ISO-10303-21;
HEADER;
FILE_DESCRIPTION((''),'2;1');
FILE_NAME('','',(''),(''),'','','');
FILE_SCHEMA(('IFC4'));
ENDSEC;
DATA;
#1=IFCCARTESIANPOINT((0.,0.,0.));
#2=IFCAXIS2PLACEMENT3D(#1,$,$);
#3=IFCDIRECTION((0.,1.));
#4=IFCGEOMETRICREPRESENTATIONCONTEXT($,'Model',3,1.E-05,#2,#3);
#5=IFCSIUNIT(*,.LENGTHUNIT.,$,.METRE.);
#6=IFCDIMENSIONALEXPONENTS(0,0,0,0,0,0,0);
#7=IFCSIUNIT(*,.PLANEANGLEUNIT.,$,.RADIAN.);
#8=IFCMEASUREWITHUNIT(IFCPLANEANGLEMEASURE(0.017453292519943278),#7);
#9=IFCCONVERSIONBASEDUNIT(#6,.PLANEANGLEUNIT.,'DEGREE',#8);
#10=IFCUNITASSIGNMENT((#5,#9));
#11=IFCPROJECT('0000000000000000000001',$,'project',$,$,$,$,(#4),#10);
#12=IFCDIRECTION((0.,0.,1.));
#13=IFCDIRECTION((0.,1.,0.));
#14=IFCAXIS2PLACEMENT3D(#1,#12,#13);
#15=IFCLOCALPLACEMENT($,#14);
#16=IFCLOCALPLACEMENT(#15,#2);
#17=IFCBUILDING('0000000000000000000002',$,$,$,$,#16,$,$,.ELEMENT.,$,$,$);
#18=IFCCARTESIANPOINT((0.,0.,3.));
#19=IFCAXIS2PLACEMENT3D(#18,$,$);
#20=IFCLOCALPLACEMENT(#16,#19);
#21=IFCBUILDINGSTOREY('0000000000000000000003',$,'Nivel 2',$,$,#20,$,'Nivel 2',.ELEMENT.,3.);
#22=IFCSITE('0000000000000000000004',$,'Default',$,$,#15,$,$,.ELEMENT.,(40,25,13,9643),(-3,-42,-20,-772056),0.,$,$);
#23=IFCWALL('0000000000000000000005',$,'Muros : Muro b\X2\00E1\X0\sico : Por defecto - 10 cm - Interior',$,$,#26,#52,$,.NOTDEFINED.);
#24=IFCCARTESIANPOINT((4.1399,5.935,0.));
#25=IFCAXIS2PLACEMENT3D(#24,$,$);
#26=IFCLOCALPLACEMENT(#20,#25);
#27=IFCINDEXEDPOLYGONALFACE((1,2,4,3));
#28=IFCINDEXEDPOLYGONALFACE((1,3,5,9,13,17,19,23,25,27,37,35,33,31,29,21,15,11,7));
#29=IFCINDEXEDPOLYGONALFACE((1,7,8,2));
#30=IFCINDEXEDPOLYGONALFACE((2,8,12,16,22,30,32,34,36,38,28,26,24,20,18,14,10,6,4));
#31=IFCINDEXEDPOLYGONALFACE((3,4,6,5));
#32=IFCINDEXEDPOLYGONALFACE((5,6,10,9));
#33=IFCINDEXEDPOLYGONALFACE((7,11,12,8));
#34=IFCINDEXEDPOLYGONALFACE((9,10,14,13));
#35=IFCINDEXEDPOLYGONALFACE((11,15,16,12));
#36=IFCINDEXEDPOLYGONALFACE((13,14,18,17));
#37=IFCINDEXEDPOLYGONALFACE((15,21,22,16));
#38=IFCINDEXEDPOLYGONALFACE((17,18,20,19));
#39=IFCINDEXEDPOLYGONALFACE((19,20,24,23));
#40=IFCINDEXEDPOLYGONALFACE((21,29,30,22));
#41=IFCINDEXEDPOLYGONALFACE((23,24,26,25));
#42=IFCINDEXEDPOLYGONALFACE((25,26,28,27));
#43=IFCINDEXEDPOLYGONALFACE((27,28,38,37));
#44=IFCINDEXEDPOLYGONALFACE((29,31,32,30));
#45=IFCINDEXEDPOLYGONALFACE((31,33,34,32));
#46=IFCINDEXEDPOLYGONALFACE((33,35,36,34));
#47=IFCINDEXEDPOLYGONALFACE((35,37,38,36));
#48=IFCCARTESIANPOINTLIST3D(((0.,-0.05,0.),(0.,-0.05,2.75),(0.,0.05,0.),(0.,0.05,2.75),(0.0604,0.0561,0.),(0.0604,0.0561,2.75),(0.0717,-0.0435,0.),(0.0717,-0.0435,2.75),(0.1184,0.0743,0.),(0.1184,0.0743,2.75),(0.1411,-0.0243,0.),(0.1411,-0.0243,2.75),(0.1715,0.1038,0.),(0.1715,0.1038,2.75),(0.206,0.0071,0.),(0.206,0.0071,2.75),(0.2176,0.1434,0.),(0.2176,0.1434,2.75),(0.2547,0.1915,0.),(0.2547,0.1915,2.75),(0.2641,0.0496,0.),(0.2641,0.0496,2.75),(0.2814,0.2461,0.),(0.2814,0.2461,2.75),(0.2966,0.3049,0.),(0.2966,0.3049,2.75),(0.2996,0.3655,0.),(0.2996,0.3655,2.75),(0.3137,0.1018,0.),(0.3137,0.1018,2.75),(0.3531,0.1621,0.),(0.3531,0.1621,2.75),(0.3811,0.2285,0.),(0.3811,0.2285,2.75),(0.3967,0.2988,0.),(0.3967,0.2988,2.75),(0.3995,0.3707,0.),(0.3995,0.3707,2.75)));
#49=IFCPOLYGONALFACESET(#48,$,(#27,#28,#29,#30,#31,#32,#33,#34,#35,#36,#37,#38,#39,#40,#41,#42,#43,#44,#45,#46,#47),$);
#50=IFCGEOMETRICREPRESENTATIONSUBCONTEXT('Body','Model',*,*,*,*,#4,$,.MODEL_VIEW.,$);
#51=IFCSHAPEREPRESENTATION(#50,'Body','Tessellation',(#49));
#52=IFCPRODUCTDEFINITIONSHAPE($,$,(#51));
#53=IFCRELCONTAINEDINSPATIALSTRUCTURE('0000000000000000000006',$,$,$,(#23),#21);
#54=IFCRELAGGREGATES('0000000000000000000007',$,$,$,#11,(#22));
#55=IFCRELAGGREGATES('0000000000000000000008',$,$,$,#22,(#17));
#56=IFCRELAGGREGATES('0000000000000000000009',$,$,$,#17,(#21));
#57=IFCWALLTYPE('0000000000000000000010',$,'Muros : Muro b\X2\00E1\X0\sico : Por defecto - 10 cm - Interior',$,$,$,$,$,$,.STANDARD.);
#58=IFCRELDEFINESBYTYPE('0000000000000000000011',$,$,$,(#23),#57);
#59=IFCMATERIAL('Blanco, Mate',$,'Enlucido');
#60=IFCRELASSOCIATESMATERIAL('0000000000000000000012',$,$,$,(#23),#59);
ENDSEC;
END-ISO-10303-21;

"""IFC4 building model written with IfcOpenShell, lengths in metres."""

from ifc_helpers import new_model, entity, si_unit, converted_unit, direction, frame, origin, place, context, subcontext, project, spatial, line, arc, indexed_curve, outline, extrude, material, type_object, element, save


model = new_model("IFC4")

# Units and contexts
model_context = context("Model", 3, precision=1e-05, world=origin(), true_north=direction((0.0, 1.0)))
body_context = subcontext(model_context, "Body", "Model", "MODEL_VIEW")
ifc_project = project(units=[si_unit("LENGTHUNIT", "METRE"), converted_unit("PLANEANGLEUNIT", "DEGREE", entity("IfcPlaneAngleMeasure", 0.017453292519943278), si_unit("PLANEANGLEUNIT", "RADIAN"), dimensions=[0, 0, 0, 0, 0, 0, 0])], contexts=[model_context])

# Site, building, storey
site_placement = place(None, frame((0.0, 0.0, 0.0), z_axis=(0.0, 0.0, 1.0), x_axis=(0.0, 1.0, 0.0)))
site = spatial("IfcSite", under=ifc_project, at=site_placement, Name="Default", CompositionType="ELEMENT", RefLatitude=(40, 25, 13, 9643), RefLongitude=(-3, -42, -20, -772056), RefElevation=0.0)
building_placement = place(site_placement, origin())
building = spatial("IfcBuilding", under=site, at=building_placement, CompositionType="ELEMENT")
storey_placement = place(building_placement, frame((0.0, 0.0, 3.0)))
storey = spatial("IfcBuildingStorey", under=building, at=storey_placement, Name="Nivel 2", LongName="Nivel 2", CompositionType="ELEMENT", Elevation=3.0)

# Wall
ifc_material_1 = material(Name="Blanco, Mate", Category="Enlucido")
wall_type_1 = type_object("IfcWallType", Name="Muros : Muro básico : Por defecto - 10 cm - Interior", PredefinedType="STANDARD")
wall_1_placement = place(storey_placement, frame((4.1399, 5.935, 0.0)))
element("IfcWall", 1, at=wall_1_placement, inside=storey, type_object=wall_type_1, material=ifc_material_1, Name="Muros : Muro básico : Por defecto - 10 cm - Interior", PredefinedType="NOTDEFINED", context=body_context, shape_type="SweptSolid", body=[
    extrude(outline(indexed_curve([(0.2996, 0.3655), (0.2176, 0.1434), (0.0, 0.05), (0.0, -0.05), (0.2901, 0.0746), (0.3995, 0.3707)], segments=[arc(1, 2, 3), line(3, 4), arc(4, 5, 6), line(6, 1)], self_intersect=False)), origin(), (0.0, 0.0, 1.0), 2.75),
])

save(model, "model.ifc")
